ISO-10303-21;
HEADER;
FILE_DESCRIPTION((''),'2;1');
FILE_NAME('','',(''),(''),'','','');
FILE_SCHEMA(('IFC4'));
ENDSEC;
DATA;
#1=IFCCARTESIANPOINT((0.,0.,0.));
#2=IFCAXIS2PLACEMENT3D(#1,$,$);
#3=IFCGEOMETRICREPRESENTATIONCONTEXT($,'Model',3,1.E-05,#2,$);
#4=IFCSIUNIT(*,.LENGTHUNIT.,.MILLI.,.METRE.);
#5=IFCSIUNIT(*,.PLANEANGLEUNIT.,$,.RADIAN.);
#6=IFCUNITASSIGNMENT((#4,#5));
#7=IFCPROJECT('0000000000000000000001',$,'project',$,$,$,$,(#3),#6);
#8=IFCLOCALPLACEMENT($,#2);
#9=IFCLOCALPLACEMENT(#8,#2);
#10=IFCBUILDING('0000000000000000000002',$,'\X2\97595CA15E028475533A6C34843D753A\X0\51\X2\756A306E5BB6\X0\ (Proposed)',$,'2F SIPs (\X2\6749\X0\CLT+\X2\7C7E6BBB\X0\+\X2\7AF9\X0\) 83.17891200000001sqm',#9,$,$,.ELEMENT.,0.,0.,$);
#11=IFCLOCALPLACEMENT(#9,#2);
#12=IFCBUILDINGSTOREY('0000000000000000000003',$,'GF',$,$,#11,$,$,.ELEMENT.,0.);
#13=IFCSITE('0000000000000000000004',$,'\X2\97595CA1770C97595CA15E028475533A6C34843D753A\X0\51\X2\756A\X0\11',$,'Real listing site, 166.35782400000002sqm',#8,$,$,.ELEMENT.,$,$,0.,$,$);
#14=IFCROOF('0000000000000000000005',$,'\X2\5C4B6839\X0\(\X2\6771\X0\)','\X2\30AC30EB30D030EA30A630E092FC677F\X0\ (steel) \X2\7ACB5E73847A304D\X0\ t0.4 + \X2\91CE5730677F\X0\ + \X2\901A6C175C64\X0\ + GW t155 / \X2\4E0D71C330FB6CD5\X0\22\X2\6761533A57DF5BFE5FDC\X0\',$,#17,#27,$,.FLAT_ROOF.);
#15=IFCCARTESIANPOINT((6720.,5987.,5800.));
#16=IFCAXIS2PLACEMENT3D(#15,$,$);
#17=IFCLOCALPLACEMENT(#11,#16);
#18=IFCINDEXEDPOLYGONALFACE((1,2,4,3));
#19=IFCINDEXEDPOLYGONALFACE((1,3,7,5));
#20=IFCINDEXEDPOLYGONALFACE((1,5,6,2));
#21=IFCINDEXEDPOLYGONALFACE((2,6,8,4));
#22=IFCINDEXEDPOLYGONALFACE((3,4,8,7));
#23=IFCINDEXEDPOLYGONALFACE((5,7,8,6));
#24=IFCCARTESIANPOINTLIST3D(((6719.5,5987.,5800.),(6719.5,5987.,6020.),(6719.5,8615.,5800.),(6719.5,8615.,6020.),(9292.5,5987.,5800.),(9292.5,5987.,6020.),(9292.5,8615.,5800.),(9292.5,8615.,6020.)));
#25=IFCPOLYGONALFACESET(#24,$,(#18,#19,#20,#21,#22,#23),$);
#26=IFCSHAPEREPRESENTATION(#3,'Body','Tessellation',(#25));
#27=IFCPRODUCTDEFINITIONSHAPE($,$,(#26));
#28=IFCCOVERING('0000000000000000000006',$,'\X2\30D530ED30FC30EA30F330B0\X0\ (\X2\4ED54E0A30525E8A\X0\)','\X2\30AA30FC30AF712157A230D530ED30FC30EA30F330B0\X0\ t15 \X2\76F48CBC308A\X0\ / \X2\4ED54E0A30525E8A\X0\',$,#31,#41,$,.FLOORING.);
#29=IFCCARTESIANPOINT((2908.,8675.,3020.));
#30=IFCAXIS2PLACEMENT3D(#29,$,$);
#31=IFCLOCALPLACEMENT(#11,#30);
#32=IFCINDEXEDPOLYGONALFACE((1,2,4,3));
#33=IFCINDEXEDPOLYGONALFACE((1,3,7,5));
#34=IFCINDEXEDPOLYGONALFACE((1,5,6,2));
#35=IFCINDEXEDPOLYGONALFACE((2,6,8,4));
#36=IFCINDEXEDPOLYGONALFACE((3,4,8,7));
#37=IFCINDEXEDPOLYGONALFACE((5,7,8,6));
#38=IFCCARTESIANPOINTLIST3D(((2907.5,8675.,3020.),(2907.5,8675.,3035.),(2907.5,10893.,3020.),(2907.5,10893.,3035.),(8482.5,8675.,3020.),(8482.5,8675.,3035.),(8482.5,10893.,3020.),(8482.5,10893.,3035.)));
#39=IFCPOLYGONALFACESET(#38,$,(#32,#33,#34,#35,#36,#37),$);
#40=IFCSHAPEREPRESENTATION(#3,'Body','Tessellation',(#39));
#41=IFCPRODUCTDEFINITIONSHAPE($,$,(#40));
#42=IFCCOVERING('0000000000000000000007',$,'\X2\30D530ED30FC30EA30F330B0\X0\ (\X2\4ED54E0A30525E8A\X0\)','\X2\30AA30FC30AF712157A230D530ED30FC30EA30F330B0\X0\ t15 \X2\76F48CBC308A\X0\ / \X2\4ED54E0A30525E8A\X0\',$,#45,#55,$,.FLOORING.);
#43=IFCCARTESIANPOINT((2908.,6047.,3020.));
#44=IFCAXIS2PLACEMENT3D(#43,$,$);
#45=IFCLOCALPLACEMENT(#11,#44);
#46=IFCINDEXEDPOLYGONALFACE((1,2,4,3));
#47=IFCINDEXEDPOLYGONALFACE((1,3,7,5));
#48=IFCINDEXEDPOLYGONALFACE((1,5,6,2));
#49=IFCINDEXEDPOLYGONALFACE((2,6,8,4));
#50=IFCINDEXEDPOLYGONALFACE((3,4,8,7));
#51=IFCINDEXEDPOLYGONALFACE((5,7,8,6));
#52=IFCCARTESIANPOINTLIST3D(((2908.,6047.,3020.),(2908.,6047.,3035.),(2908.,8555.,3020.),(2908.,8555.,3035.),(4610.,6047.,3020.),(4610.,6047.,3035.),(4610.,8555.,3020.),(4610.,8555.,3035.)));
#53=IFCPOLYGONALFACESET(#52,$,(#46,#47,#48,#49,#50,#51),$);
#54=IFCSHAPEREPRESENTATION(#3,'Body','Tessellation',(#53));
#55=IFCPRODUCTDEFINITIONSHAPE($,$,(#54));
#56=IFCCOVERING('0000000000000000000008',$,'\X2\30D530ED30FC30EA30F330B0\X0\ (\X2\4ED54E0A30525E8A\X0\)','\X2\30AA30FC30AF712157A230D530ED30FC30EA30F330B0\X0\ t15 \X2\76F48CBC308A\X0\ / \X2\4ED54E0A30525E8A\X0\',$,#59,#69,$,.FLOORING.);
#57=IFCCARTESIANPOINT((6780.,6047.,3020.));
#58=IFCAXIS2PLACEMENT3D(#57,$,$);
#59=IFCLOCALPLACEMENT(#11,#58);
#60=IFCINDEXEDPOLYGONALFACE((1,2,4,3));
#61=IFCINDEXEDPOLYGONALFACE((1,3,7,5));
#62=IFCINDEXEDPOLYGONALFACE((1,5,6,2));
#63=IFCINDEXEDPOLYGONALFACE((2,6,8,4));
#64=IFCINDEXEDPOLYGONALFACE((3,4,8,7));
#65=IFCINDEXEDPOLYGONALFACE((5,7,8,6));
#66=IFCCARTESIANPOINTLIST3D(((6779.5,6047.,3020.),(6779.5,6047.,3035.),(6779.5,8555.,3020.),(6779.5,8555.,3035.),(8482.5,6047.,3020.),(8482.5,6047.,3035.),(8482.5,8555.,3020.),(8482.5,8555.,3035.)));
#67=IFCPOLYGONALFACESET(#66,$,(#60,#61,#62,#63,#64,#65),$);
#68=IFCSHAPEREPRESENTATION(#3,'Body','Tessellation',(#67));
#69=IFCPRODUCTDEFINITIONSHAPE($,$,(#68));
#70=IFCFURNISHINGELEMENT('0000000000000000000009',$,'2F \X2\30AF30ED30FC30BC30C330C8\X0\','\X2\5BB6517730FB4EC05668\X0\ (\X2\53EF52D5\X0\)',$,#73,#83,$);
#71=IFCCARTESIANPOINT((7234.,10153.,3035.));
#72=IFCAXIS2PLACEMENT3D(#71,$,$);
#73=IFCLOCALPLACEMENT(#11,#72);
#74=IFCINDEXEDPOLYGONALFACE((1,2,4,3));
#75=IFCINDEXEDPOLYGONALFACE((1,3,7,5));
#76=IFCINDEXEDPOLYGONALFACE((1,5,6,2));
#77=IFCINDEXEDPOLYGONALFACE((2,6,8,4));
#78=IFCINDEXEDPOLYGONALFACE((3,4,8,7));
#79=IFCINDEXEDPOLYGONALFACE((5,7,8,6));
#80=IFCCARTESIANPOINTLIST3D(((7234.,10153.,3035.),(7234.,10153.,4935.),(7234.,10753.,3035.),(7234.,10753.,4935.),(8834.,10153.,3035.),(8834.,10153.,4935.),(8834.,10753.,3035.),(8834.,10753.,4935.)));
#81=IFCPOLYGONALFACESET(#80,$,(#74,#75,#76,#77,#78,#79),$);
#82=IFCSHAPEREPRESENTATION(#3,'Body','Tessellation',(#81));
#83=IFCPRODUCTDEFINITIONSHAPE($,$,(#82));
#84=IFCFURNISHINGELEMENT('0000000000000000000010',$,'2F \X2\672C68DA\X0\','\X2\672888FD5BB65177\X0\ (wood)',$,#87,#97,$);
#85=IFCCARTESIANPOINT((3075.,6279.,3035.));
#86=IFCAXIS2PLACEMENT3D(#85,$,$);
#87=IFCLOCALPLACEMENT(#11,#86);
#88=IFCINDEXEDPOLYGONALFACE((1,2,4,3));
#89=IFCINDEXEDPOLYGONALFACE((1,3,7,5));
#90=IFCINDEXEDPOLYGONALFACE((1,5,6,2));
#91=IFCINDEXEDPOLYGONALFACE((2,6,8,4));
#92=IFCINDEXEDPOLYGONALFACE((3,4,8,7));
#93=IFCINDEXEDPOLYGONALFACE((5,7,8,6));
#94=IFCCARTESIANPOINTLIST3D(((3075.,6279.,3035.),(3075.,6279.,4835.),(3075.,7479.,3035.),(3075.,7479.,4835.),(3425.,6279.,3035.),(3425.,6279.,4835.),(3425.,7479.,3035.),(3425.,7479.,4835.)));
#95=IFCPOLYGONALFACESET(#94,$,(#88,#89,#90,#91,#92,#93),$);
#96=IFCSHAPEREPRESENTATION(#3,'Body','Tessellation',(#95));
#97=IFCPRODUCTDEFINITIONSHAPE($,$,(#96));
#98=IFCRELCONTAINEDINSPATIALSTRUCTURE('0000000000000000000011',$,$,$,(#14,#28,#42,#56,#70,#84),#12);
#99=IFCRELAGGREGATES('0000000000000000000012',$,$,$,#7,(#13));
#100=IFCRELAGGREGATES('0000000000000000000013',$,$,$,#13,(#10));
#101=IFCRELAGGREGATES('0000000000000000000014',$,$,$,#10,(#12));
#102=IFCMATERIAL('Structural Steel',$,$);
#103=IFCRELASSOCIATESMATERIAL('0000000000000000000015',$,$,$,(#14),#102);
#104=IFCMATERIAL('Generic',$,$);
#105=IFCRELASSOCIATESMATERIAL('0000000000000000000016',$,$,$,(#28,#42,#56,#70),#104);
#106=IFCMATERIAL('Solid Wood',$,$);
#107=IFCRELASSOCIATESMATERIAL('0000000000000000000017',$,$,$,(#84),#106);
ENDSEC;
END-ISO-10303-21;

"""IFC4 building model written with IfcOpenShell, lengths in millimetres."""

from ifc_helpers import new_model, si_unit, frame, frame_2d, origin, place, context, project, spatial, rectangle, extrude, material, element, save


model = new_model("IFC4")

# Units and contexts
model_context = context("Model", 3, precision=1e-05, world=origin())
ifc_project = project(units=[si_unit("LENGTHUNIT", "METRE", prefix="MILLI"), si_unit("PLANEANGLEUNIT", "RADIAN")], contexts=[model_context])

# Site, building, storey
site_placement = place(None, origin())
site = spatial("IfcSite", under=ifc_project, at=site_placement, Name="静岡県静岡市葵区水落町51番11", ObjectType="Real listing site, 166.35782400000002sqm", CompositionType="ELEMENT", RefElevation=0.0)
building_placement = place(site_placement, origin())
building = spatial("IfcBuilding", under=site, at=building_placement, Name="静岡市葵区水落町51番の家 (Proposed)", ObjectType="2F SIPs (杉CLT+籾殻+竹) 83.17891200000001sqm", CompositionType="ELEMENT", ElevationOfRefHeight=0.0, ElevationOfTerrain=0.0)
storey_placement = place(building_placement, origin())
storey = spatial("IfcBuildingStorey", under=building, at=storey_placement, Name="GF", CompositionType="ELEMENT", Elevation=0.0)

# Shared definitions
ifc_material_1 = material(Name="Solid Wood")

# Roof
ifc_material_2 = material(Name="Structural Steel")
roof_1_placement = place(storey_placement, frame((6720.0, 5987.0, 5800.0)))
element("IfcRoof", 1, at=roof_1_placement, inside=storey, material=ifc_material_2, Name="屋根(東)", Description="ガルバリウム鋼板 (steel) 立平葺き t0.4 + 野地板 + 通気層 + GW t155 / 不燃・法22条区域対応", PredefinedType="FLAT_ROOF", context=model_context, shape_type="SweptSolid", body=[
    extrude(rectangle(XDim=2573.0, YDim=2628.0, at=frame_2d((1286.0, 1314.0))), frame((6720.0, 5987.0, 5800.0)), (0.0, 0.0, 1.0), 220.0),
])

# Coverings
ifc_material_3 = material(Name="Generic")
covering_1_placement = place(storey_placement, frame((2908.0, 8675.0, 3020.0)))
element("IfcCovering", 2, at=covering_1_placement, inside=storey, material=ifc_material_3, Name="フローリング (仕上げ床)", Description="オーク無垢フローリング t15 直貼り / 仕上げ床", PredefinedType="FLOORING", context=model_context, shape_type="SweptSolid", body=[
    extrude(rectangle(XDim=5575.0, YDim=2218.0, at=frame_2d((2787.0, 1109.0))), frame((2908.0, 8675.0, 3020.0)), (0.0, 0.0, 1.0), 15.0),
])
covering_2_placement = place(storey_placement, frame((2908.0, 6047.0, 3020.0)))
element("IfcCovering", 3, at=covering_2_placement, inside=storey, material=ifc_material_3, Name="フローリング (仕上げ床)", Description="オーク無垢フローリング t15 直貼り / 仕上げ床", PredefinedType="FLOORING", context=model_context, shape_type="SweptSolid", body=[
    extrude(rectangle(XDim=1702.0, YDim=2508.0, at=frame_2d((851.0, 1254.0))), frame((2908.0, 6047.0, 3020.0)), (0.0, 0.0, 1.0), 15.0),
])
covering_3_placement = place(storey_placement, frame((6780.0, 6047.0, 3020.0)))
element("IfcCovering", 4, at=covering_3_placement, inside=storey, material=ifc_material_3, Name="フローリング (仕上げ床)", Description="オーク無垢フローリング t15 直貼り / 仕上げ床", PredefinedType="FLOORING", context=model_context, shape_type="SweptSolid", body=[
    extrude(rectangle(XDim=1703.0, YDim=2508.0, at=frame_2d((851.0, 1254.0))), frame((6780.0, 6047.0, 3020.0)), (0.0, 0.0, 1.0), 15.0),
])

# Furnishing elements
furnishing_1_placement = place(storey_placement, frame((7234.0, 10153.0, 3035.0)))
element("IfcFurnishingElement", 5, at=furnishing_1_placement, inside=storey, material=ifc_material_3, Name="2F クローゼット", Description="家具・什器 (可動)", context=model_context, shape_type="SweptSolid", body=[
    extrude(rectangle(XDim=1600.0, YDim=600.0, at=frame_2d((800.0, 300.0))), frame((7234.0, 10153.0, 3035.0)), (0.0, 0.0, 1.0), 1900.0),
])
furnishing_2_placement = place(storey_placement, frame((3075.0, 6279.0, 3035.0)))
element("IfcFurnishingElement", 6, at=furnishing_2_placement, inside=storey, material=ifc_material_1, Name="2F 本棚", Description="木製家具 (wood)", context=model_context, shape_type="SweptSolid", body=[
    extrude(rectangle(XDim=350.0, YDim=1200.0, at=frame_2d((175.0, 600.0))), frame((3075.0, 6279.0, 3035.0)), (0.0, 0.0, 1.0), 1800.0),
])

save(model, "model.ifc")
